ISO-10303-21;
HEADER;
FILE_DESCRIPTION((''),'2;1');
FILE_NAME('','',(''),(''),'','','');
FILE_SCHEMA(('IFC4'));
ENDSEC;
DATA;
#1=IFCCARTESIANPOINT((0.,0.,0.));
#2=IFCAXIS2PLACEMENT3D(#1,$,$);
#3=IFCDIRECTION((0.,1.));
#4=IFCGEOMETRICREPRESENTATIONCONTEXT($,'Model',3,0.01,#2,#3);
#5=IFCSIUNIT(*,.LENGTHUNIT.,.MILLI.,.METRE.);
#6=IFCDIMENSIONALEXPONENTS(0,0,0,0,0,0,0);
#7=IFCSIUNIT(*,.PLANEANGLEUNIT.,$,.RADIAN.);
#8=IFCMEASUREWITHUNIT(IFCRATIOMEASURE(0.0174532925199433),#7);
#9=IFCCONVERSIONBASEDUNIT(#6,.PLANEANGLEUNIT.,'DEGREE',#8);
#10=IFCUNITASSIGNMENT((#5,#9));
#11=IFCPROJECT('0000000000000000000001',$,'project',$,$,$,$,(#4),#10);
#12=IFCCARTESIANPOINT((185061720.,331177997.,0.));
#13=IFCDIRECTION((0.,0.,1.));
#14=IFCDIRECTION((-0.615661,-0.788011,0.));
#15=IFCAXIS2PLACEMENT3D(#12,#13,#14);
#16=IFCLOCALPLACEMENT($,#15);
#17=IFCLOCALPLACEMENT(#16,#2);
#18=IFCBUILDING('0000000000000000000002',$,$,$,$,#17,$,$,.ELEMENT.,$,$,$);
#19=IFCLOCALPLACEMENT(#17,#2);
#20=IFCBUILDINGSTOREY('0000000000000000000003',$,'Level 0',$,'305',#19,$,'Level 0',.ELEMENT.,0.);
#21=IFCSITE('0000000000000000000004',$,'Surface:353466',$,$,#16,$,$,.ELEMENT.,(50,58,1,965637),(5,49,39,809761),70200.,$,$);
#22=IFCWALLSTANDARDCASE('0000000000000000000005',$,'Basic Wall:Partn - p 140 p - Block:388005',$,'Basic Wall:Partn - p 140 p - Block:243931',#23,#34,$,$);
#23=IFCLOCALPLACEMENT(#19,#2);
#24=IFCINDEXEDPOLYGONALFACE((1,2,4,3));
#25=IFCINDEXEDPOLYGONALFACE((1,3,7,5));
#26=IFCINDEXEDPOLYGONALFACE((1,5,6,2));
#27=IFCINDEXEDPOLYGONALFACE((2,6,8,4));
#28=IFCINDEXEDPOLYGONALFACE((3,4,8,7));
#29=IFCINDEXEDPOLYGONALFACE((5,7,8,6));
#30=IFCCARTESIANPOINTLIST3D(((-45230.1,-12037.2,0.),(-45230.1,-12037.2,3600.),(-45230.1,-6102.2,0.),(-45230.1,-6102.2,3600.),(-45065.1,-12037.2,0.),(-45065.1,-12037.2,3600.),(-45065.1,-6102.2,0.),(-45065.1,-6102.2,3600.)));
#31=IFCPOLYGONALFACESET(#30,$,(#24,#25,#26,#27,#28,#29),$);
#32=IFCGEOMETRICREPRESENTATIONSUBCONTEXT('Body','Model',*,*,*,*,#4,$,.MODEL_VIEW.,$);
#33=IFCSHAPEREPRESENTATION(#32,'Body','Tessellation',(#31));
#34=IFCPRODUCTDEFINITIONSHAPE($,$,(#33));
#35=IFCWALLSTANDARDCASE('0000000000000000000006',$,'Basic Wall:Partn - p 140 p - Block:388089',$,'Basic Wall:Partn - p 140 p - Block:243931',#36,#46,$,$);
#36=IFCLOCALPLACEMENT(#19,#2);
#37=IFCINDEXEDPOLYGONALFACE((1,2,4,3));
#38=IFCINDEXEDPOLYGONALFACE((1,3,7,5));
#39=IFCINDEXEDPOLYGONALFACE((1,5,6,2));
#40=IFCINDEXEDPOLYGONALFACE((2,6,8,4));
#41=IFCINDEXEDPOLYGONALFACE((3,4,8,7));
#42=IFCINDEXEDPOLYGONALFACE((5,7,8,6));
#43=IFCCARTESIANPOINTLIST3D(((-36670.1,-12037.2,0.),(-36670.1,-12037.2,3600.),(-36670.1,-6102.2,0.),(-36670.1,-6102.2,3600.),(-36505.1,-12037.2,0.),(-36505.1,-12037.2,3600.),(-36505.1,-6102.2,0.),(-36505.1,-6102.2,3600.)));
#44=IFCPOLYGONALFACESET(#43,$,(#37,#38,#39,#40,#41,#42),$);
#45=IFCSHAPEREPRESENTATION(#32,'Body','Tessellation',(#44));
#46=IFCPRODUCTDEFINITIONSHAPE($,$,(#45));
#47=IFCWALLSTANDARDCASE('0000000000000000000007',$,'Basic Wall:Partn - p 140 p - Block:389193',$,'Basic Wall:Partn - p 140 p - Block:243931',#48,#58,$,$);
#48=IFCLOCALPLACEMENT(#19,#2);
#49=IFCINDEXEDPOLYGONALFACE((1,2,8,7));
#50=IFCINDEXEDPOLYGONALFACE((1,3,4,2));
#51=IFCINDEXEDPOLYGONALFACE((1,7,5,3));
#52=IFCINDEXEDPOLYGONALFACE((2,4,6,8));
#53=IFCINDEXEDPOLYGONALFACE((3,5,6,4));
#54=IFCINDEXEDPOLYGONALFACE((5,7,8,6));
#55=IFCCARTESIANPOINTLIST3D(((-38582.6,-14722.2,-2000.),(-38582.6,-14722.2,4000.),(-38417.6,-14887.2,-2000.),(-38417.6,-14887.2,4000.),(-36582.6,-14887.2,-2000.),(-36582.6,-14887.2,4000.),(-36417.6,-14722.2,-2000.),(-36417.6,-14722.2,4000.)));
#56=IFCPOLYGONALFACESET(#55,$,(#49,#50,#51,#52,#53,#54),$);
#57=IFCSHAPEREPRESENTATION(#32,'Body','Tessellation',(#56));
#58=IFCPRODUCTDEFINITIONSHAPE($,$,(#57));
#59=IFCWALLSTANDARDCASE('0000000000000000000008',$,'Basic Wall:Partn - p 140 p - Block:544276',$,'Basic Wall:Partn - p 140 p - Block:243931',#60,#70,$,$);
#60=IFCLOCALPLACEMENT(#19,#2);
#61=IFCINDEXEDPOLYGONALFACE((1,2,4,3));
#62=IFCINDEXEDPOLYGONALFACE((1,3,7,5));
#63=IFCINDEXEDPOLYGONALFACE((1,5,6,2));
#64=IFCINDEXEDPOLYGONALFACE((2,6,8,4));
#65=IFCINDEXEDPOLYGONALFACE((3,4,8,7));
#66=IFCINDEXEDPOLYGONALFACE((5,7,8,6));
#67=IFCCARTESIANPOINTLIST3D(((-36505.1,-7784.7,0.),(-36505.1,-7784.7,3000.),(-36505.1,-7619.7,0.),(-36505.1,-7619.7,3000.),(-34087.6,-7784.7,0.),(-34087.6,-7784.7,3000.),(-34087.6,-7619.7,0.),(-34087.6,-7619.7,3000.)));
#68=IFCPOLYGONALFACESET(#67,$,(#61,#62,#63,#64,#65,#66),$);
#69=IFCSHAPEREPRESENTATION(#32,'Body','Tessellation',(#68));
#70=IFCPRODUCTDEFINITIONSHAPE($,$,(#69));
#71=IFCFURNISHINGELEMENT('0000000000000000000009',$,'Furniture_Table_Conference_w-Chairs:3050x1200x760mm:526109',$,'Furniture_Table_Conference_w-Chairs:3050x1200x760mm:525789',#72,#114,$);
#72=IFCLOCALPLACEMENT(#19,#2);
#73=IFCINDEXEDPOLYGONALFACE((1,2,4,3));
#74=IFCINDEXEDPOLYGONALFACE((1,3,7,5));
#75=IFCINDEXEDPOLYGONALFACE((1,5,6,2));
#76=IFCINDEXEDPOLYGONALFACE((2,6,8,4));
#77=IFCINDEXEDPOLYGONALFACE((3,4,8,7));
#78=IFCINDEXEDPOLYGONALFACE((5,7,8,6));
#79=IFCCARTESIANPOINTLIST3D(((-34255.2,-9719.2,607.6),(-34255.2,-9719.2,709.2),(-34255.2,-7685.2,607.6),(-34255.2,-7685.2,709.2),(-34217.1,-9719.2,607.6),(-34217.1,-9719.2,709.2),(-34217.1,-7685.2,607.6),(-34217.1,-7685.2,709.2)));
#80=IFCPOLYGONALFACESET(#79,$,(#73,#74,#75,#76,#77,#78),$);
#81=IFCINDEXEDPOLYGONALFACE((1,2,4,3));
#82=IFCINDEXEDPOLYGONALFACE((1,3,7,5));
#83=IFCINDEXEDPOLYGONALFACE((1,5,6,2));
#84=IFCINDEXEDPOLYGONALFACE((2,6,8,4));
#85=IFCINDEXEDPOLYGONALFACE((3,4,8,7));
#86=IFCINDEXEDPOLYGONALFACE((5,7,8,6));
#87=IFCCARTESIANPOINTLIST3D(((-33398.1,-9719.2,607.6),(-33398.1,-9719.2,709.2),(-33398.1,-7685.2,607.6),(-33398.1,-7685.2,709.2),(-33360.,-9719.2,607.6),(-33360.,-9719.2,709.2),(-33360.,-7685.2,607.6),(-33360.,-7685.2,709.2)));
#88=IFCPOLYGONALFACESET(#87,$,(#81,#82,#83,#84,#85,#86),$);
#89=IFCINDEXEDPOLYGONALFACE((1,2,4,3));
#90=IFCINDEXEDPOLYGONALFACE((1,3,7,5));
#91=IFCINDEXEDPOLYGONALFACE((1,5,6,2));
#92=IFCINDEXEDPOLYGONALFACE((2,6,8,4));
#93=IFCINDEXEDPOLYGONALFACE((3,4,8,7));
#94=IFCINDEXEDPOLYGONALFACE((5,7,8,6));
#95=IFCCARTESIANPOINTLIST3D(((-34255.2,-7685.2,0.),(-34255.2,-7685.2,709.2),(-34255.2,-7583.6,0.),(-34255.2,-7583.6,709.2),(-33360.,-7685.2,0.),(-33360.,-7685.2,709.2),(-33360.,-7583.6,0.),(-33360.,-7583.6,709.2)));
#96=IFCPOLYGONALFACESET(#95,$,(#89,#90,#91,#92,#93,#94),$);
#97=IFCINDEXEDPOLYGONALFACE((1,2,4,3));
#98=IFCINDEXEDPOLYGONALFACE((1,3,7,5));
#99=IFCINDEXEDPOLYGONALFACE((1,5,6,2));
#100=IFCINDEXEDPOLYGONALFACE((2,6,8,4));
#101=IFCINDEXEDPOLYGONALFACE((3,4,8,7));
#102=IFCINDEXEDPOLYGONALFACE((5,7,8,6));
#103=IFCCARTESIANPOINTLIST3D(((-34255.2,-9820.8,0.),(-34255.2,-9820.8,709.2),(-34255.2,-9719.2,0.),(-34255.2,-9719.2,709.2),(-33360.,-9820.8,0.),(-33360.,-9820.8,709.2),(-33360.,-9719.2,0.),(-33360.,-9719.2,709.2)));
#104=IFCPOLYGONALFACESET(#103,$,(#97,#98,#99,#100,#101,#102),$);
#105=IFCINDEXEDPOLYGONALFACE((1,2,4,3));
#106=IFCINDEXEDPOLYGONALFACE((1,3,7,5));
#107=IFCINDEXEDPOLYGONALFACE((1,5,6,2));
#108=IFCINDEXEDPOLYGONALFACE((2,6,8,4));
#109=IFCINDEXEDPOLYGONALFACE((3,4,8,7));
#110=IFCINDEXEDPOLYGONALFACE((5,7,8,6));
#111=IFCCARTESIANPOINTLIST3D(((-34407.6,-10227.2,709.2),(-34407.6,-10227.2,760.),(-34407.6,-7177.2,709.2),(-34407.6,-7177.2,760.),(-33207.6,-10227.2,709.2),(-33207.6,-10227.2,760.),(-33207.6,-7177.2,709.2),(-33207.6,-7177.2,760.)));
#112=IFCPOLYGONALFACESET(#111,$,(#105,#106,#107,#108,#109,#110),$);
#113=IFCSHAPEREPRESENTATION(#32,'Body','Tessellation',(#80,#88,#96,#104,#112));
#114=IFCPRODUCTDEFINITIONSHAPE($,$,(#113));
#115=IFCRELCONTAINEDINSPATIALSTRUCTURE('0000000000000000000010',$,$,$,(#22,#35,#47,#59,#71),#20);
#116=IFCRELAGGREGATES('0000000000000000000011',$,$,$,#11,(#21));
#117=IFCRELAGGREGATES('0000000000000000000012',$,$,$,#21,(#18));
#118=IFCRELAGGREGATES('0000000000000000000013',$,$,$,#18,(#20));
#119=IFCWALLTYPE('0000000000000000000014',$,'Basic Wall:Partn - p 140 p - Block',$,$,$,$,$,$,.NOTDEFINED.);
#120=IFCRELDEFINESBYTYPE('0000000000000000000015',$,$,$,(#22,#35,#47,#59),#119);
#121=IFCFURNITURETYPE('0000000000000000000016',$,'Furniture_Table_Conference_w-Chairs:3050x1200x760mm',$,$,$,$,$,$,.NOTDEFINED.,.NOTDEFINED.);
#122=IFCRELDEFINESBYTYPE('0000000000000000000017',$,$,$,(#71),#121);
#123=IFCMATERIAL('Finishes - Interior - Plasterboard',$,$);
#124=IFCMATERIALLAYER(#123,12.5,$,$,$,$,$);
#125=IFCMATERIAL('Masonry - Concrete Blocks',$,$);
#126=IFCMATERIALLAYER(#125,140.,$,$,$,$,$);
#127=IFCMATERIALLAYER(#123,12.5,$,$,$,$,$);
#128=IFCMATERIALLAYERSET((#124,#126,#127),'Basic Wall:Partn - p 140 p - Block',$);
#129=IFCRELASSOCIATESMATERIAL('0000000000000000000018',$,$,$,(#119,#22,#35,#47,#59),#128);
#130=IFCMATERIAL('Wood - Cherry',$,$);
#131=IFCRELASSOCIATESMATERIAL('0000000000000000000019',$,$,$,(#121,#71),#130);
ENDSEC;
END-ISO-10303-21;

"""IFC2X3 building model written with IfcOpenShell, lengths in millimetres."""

from ifc_helpers import new_model, entity, si_unit, converted_unit, direction, frame, frame_2d, origin, origin_2d_with_axis, place, context, subcontext, project, spatial, polyline, rectangle, outline, extrude, clip, halfspace, bounded_halfspace, source, transform, mapped, material, layer, layer_set, layer_usage, type_object, type_shapes, element, save


model = new_model("IFC2X3")

# Units and contexts
model_context = context("Model", 3, precision=0.01, world=origin(), true_north=direction((0.0, 1.0)))
body_context = subcontext(model_context, "Body", "Model", "MODEL_VIEW")
ifc_project = project(units=[si_unit("LENGTHUNIT", "METRE", prefix="MILLI"), converted_unit("PLANEANGLEUNIT", "DEGREE", entity("IfcRatioMeasure", 0.0174532925199433), si_unit("PLANEANGLEUNIT", "RADIAN"), dimensions=[0, 0, 0, 0, 0, 0, 0])], contexts=[model_context])

# Site, building, storey
site_placement = place(None, frame((185061720.0, 331177997.0, 0.0), z_axis=(0.0, 0.0, 1.0), x_axis=(-0.615661, -0.788011, 0.0)))
site = spatial("IfcSite", under=ifc_project, at=site_placement, Name="Surface:353466", CompositionType="ELEMENT", RefLatitude=(50, 58, 1, 965637), RefLongitude=(5, 49, 39, 809761), RefElevation=70200.0)
building_placement = place(site_placement, origin())
building = spatial("IfcBuilding", under=site, at=building_placement, CompositionType="ELEMENT")
storey_placement = place(building_placement, origin())
storey = spatial("IfcBuildingStorey", under=building, at=storey_placement, Name="Level 0", ObjectType="305", LongName="Level 0", CompositionType="ELEMENT", Elevation=0.0)

# Shared definitions
ifc_material_1 = material(Name="Masonry - Concrete Blocks")
ifc_material_2 = material(Name="Finishes - Interior - Plasterboard")

# Walls
ifc_layer_1 = layer(ifc_material_2, 12.5)
ifc_layer_2 = layer(ifc_material_1, 140.0)
ifc_layer_3 = layer(ifc_material_2, 12.5)
ifc_layer_set_1 = layer_set([ifc_layer_1, ifc_layer_2, ifc_layer_3], Name="Basic Wall:Partn - p 140 p - Block")
ifc_layer_usage_1 = layer_usage(ifc_layer_set_1, "AXIS2", "NEGATIVE", 82.5)
wall_type_1 = type_object("IfcWallType", Name="Basic Wall:Partn - p 140 p - Block", PredefinedType="NOTDEFINED", material=ifc_layer_set_1)
wall_1_placement = place(storey_placement, frame((-45147.6, -6102.2, 0.0), z_axis=(0.0, 0.0, 1.0), x_axis=(0.0, -1.0, 0.0)))
element("IfcWallStandardCase", 1, at=wall_1_placement, inside=storey, type_object=wall_type_1, material=ifc_layer_usage_1, Name="Basic Wall:Partn - p 140 p - Block:388005", ObjectType="Basic Wall:Partn - p 140 p - Block:243931", context=body_context, shape_type="Clipping", body=[
    clip(extrude(rectangle(XDim=5935.0, YDim=165.0, at=frame_2d((2967.5, 0.0), x_axis=(-1.0, 0.0))), origin(), (0.0, 0.0, 1.0), 3600.0), bounded_halfspace(frame((0.0, -82.5, 3600.0), z_axis=(0.0, 0.0, -1.0), x_axis=(0.0, 1.0, 0.0)), True, frame((0.0, -82.5, 3600.0)), polyline([(0.0, 0.0), (5935.0, 0.0), (5935.0, 165.0), (0.0, 165.0), (0.0, 0.0)]))),
])
ifc_layer_usage_2 = layer_usage(ifc_layer_set_1, "AXIS2", "NEGATIVE", 82.5)
wall_2_placement = place(storey_placement, frame((-36587.6, -6102.2, 0.0), z_axis=(0.0, 0.0, 1.0), x_axis=(0.0, -1.0, 0.0)))
element("IfcWallStandardCase", 2, at=wall_2_placement, inside=storey, type_object=wall_type_1, material=ifc_layer_usage_2, Name="Basic Wall:Partn - p 140 p - Block:388089", ObjectType="Basic Wall:Partn - p 140 p - Block:243931", context=body_context, shape_type="Clipping", body=[
    clip(extrude(rectangle(XDim=5935.0, YDim=165.0, at=frame_2d((2967.5, 0.0), x_axis=(-1.0, 0.0))), origin(), (0.0, 0.0, 1.0), 3600.0), bounded_halfspace(frame((0.0, -82.5, 3600.0), z_axis=(0.0, 0.0, -1.0), x_axis=(0.0, 1.0, 0.0)), True, frame((0.0, -82.5, 3600.0)), polyline([(0.0, 0.0), (5935.0, 0.0), (5935.0, 165.0), (0.0, 165.0), (0.0, 0.0)]))),
])
ifc_layer_usage_3 = layer_usage(ifc_layer_set_1, "AXIS2", "NEGATIVE", 82.5)
wall_3_placement = place(storey_placement, frame((-38582.6, -14804.7, -2000.0)))
element("IfcWallStandardCase", 3, at=wall_3_placement, inside=storey, type_object=wall_type_1, material=ifc_layer_usage_3, Name="Basic Wall:Partn - p 140 p - Block:389193", ObjectType="Basic Wall:Partn - p 140 p - Block:243931", context=body_context, shape_type="Clipping", body=[
    clip(extrude(outline(polyline([(2000.0, -82.5), (2165.0, 82.5), (0.0, 82.5), (165.0, -82.5), (2000.0, -82.5)])), origin(), (0.0, 0.0, 1.0), 6000.0), halfspace(frame((0.0, 0.0, -2000.0)), True)),
])
ifc_layer_usage_4 = layer_usage(ifc_layer_set_1, "AXIS2", "NEGATIVE", 82.5)
wall_4_placement = place(storey_placement, frame((-36505.1, -7702.2, 0.0)))
element("IfcWallStandardCase", 4, at=wall_4_placement, inside=storey, type_object=wall_type_1, material=ifc_layer_usage_4, Name="Basic Wall:Partn - p 140 p - Block:544276", ObjectType="Basic Wall:Partn - p 140 p - Block:243931", context=body_context, shape_type="SweptSolid", body=[
    extrude(rectangle(XDim=2417.5, YDim=165.0, at=frame_2d((1208.8, 0.0), x_axis=(-1.0, 0.0))), origin(), (0.0, 0.0, 1.0), 3000.0),
])

# Furnishing element
ifc_material_3 = material(Name="Wood - Cherry")
furniture_type_1 = type_object("IfcFurnitureType", Name="Furniture_Table_Conference_w-Chairs:3050x1200x760mm", material=ifc_material_3)
shared_shape_1 = source(origin(), body_context, "Body", "SweptSolid", [
    extrude(rectangle(XDim=2034.0, YDim=38.1, at=origin_2d_with_axis()), frame((0.0, 428.6, 607.6), z_axis=(0.0, 0.0, 1.0), x_axis=(-1.0, 0.0, 0.0)), (0.0, 0.0, 1.0), 101.6),
    extrude(rectangle(XDim=38.1, YDim=2034.0, at=origin_2d_with_axis()), frame((0.0, -428.6, 607.6), z_axis=(0.0, 0.0, 1.0), x_axis=(0.0, 1.0, 0.0)), (0.0, 0.0, 1.0), 101.6),
    extrude(rectangle(XDim=895.2, YDim=101.6, at=origin_2d_with_axis()), frame((1067.8, 0.0, 0.0), z_axis=(0.0, 0.0, 1.0), x_axis=(0.0, 1.0, 0.0)), (0.0, 0.0, 1.0), 709.2),
    extrude(rectangle(XDim=895.2, YDim=101.6, at=frame_2d((0.0, 0.0), x_axis=(1.0, 0.0))), frame((-1067.8, 0.0, 0.0), z_axis=(0.0, 0.0, 1.0), x_axis=(0.0, 1.0, 0.0)), (0.0, 0.0, 1.0), 709.2),
    extrude(rectangle(XDim=1200.0, YDim=3050.0, at=origin_2d_with_axis()), frame((0.0, 0.0, 709.2), z_axis=(0.0, 0.0, 1.0), x_axis=(0.0, 1.0, 0.0)), (0.0, 0.0, 1.0), 50.8),
])
type_shapes(furniture_type_1, [shared_shape_1])
furnishing_1_placement = place(storey_placement, frame((-33807.6, -8702.2, 0.0), z_axis=(0.0, 0.0, 1.0), x_axis=(0.0, 1.0, 0.0)))
element("IfcFurnishingElement", 5, at=furnishing_1_placement, inside=storey, type_object=furniture_type_1, material=ifc_material_3, Name="Furniture_Table_Conference_w-Chairs:3050x1200x760mm:526109", ObjectType="Furniture_Table_Conference_w-Chairs:3050x1200x760mm:525789", context=body_context, shape_type="MappedRepresentation", body=[
    mapped(shared_shape_1, transform((0.0, 0.0, 0.0), scale=1.0)),
])

save(model, "model.ifc")
